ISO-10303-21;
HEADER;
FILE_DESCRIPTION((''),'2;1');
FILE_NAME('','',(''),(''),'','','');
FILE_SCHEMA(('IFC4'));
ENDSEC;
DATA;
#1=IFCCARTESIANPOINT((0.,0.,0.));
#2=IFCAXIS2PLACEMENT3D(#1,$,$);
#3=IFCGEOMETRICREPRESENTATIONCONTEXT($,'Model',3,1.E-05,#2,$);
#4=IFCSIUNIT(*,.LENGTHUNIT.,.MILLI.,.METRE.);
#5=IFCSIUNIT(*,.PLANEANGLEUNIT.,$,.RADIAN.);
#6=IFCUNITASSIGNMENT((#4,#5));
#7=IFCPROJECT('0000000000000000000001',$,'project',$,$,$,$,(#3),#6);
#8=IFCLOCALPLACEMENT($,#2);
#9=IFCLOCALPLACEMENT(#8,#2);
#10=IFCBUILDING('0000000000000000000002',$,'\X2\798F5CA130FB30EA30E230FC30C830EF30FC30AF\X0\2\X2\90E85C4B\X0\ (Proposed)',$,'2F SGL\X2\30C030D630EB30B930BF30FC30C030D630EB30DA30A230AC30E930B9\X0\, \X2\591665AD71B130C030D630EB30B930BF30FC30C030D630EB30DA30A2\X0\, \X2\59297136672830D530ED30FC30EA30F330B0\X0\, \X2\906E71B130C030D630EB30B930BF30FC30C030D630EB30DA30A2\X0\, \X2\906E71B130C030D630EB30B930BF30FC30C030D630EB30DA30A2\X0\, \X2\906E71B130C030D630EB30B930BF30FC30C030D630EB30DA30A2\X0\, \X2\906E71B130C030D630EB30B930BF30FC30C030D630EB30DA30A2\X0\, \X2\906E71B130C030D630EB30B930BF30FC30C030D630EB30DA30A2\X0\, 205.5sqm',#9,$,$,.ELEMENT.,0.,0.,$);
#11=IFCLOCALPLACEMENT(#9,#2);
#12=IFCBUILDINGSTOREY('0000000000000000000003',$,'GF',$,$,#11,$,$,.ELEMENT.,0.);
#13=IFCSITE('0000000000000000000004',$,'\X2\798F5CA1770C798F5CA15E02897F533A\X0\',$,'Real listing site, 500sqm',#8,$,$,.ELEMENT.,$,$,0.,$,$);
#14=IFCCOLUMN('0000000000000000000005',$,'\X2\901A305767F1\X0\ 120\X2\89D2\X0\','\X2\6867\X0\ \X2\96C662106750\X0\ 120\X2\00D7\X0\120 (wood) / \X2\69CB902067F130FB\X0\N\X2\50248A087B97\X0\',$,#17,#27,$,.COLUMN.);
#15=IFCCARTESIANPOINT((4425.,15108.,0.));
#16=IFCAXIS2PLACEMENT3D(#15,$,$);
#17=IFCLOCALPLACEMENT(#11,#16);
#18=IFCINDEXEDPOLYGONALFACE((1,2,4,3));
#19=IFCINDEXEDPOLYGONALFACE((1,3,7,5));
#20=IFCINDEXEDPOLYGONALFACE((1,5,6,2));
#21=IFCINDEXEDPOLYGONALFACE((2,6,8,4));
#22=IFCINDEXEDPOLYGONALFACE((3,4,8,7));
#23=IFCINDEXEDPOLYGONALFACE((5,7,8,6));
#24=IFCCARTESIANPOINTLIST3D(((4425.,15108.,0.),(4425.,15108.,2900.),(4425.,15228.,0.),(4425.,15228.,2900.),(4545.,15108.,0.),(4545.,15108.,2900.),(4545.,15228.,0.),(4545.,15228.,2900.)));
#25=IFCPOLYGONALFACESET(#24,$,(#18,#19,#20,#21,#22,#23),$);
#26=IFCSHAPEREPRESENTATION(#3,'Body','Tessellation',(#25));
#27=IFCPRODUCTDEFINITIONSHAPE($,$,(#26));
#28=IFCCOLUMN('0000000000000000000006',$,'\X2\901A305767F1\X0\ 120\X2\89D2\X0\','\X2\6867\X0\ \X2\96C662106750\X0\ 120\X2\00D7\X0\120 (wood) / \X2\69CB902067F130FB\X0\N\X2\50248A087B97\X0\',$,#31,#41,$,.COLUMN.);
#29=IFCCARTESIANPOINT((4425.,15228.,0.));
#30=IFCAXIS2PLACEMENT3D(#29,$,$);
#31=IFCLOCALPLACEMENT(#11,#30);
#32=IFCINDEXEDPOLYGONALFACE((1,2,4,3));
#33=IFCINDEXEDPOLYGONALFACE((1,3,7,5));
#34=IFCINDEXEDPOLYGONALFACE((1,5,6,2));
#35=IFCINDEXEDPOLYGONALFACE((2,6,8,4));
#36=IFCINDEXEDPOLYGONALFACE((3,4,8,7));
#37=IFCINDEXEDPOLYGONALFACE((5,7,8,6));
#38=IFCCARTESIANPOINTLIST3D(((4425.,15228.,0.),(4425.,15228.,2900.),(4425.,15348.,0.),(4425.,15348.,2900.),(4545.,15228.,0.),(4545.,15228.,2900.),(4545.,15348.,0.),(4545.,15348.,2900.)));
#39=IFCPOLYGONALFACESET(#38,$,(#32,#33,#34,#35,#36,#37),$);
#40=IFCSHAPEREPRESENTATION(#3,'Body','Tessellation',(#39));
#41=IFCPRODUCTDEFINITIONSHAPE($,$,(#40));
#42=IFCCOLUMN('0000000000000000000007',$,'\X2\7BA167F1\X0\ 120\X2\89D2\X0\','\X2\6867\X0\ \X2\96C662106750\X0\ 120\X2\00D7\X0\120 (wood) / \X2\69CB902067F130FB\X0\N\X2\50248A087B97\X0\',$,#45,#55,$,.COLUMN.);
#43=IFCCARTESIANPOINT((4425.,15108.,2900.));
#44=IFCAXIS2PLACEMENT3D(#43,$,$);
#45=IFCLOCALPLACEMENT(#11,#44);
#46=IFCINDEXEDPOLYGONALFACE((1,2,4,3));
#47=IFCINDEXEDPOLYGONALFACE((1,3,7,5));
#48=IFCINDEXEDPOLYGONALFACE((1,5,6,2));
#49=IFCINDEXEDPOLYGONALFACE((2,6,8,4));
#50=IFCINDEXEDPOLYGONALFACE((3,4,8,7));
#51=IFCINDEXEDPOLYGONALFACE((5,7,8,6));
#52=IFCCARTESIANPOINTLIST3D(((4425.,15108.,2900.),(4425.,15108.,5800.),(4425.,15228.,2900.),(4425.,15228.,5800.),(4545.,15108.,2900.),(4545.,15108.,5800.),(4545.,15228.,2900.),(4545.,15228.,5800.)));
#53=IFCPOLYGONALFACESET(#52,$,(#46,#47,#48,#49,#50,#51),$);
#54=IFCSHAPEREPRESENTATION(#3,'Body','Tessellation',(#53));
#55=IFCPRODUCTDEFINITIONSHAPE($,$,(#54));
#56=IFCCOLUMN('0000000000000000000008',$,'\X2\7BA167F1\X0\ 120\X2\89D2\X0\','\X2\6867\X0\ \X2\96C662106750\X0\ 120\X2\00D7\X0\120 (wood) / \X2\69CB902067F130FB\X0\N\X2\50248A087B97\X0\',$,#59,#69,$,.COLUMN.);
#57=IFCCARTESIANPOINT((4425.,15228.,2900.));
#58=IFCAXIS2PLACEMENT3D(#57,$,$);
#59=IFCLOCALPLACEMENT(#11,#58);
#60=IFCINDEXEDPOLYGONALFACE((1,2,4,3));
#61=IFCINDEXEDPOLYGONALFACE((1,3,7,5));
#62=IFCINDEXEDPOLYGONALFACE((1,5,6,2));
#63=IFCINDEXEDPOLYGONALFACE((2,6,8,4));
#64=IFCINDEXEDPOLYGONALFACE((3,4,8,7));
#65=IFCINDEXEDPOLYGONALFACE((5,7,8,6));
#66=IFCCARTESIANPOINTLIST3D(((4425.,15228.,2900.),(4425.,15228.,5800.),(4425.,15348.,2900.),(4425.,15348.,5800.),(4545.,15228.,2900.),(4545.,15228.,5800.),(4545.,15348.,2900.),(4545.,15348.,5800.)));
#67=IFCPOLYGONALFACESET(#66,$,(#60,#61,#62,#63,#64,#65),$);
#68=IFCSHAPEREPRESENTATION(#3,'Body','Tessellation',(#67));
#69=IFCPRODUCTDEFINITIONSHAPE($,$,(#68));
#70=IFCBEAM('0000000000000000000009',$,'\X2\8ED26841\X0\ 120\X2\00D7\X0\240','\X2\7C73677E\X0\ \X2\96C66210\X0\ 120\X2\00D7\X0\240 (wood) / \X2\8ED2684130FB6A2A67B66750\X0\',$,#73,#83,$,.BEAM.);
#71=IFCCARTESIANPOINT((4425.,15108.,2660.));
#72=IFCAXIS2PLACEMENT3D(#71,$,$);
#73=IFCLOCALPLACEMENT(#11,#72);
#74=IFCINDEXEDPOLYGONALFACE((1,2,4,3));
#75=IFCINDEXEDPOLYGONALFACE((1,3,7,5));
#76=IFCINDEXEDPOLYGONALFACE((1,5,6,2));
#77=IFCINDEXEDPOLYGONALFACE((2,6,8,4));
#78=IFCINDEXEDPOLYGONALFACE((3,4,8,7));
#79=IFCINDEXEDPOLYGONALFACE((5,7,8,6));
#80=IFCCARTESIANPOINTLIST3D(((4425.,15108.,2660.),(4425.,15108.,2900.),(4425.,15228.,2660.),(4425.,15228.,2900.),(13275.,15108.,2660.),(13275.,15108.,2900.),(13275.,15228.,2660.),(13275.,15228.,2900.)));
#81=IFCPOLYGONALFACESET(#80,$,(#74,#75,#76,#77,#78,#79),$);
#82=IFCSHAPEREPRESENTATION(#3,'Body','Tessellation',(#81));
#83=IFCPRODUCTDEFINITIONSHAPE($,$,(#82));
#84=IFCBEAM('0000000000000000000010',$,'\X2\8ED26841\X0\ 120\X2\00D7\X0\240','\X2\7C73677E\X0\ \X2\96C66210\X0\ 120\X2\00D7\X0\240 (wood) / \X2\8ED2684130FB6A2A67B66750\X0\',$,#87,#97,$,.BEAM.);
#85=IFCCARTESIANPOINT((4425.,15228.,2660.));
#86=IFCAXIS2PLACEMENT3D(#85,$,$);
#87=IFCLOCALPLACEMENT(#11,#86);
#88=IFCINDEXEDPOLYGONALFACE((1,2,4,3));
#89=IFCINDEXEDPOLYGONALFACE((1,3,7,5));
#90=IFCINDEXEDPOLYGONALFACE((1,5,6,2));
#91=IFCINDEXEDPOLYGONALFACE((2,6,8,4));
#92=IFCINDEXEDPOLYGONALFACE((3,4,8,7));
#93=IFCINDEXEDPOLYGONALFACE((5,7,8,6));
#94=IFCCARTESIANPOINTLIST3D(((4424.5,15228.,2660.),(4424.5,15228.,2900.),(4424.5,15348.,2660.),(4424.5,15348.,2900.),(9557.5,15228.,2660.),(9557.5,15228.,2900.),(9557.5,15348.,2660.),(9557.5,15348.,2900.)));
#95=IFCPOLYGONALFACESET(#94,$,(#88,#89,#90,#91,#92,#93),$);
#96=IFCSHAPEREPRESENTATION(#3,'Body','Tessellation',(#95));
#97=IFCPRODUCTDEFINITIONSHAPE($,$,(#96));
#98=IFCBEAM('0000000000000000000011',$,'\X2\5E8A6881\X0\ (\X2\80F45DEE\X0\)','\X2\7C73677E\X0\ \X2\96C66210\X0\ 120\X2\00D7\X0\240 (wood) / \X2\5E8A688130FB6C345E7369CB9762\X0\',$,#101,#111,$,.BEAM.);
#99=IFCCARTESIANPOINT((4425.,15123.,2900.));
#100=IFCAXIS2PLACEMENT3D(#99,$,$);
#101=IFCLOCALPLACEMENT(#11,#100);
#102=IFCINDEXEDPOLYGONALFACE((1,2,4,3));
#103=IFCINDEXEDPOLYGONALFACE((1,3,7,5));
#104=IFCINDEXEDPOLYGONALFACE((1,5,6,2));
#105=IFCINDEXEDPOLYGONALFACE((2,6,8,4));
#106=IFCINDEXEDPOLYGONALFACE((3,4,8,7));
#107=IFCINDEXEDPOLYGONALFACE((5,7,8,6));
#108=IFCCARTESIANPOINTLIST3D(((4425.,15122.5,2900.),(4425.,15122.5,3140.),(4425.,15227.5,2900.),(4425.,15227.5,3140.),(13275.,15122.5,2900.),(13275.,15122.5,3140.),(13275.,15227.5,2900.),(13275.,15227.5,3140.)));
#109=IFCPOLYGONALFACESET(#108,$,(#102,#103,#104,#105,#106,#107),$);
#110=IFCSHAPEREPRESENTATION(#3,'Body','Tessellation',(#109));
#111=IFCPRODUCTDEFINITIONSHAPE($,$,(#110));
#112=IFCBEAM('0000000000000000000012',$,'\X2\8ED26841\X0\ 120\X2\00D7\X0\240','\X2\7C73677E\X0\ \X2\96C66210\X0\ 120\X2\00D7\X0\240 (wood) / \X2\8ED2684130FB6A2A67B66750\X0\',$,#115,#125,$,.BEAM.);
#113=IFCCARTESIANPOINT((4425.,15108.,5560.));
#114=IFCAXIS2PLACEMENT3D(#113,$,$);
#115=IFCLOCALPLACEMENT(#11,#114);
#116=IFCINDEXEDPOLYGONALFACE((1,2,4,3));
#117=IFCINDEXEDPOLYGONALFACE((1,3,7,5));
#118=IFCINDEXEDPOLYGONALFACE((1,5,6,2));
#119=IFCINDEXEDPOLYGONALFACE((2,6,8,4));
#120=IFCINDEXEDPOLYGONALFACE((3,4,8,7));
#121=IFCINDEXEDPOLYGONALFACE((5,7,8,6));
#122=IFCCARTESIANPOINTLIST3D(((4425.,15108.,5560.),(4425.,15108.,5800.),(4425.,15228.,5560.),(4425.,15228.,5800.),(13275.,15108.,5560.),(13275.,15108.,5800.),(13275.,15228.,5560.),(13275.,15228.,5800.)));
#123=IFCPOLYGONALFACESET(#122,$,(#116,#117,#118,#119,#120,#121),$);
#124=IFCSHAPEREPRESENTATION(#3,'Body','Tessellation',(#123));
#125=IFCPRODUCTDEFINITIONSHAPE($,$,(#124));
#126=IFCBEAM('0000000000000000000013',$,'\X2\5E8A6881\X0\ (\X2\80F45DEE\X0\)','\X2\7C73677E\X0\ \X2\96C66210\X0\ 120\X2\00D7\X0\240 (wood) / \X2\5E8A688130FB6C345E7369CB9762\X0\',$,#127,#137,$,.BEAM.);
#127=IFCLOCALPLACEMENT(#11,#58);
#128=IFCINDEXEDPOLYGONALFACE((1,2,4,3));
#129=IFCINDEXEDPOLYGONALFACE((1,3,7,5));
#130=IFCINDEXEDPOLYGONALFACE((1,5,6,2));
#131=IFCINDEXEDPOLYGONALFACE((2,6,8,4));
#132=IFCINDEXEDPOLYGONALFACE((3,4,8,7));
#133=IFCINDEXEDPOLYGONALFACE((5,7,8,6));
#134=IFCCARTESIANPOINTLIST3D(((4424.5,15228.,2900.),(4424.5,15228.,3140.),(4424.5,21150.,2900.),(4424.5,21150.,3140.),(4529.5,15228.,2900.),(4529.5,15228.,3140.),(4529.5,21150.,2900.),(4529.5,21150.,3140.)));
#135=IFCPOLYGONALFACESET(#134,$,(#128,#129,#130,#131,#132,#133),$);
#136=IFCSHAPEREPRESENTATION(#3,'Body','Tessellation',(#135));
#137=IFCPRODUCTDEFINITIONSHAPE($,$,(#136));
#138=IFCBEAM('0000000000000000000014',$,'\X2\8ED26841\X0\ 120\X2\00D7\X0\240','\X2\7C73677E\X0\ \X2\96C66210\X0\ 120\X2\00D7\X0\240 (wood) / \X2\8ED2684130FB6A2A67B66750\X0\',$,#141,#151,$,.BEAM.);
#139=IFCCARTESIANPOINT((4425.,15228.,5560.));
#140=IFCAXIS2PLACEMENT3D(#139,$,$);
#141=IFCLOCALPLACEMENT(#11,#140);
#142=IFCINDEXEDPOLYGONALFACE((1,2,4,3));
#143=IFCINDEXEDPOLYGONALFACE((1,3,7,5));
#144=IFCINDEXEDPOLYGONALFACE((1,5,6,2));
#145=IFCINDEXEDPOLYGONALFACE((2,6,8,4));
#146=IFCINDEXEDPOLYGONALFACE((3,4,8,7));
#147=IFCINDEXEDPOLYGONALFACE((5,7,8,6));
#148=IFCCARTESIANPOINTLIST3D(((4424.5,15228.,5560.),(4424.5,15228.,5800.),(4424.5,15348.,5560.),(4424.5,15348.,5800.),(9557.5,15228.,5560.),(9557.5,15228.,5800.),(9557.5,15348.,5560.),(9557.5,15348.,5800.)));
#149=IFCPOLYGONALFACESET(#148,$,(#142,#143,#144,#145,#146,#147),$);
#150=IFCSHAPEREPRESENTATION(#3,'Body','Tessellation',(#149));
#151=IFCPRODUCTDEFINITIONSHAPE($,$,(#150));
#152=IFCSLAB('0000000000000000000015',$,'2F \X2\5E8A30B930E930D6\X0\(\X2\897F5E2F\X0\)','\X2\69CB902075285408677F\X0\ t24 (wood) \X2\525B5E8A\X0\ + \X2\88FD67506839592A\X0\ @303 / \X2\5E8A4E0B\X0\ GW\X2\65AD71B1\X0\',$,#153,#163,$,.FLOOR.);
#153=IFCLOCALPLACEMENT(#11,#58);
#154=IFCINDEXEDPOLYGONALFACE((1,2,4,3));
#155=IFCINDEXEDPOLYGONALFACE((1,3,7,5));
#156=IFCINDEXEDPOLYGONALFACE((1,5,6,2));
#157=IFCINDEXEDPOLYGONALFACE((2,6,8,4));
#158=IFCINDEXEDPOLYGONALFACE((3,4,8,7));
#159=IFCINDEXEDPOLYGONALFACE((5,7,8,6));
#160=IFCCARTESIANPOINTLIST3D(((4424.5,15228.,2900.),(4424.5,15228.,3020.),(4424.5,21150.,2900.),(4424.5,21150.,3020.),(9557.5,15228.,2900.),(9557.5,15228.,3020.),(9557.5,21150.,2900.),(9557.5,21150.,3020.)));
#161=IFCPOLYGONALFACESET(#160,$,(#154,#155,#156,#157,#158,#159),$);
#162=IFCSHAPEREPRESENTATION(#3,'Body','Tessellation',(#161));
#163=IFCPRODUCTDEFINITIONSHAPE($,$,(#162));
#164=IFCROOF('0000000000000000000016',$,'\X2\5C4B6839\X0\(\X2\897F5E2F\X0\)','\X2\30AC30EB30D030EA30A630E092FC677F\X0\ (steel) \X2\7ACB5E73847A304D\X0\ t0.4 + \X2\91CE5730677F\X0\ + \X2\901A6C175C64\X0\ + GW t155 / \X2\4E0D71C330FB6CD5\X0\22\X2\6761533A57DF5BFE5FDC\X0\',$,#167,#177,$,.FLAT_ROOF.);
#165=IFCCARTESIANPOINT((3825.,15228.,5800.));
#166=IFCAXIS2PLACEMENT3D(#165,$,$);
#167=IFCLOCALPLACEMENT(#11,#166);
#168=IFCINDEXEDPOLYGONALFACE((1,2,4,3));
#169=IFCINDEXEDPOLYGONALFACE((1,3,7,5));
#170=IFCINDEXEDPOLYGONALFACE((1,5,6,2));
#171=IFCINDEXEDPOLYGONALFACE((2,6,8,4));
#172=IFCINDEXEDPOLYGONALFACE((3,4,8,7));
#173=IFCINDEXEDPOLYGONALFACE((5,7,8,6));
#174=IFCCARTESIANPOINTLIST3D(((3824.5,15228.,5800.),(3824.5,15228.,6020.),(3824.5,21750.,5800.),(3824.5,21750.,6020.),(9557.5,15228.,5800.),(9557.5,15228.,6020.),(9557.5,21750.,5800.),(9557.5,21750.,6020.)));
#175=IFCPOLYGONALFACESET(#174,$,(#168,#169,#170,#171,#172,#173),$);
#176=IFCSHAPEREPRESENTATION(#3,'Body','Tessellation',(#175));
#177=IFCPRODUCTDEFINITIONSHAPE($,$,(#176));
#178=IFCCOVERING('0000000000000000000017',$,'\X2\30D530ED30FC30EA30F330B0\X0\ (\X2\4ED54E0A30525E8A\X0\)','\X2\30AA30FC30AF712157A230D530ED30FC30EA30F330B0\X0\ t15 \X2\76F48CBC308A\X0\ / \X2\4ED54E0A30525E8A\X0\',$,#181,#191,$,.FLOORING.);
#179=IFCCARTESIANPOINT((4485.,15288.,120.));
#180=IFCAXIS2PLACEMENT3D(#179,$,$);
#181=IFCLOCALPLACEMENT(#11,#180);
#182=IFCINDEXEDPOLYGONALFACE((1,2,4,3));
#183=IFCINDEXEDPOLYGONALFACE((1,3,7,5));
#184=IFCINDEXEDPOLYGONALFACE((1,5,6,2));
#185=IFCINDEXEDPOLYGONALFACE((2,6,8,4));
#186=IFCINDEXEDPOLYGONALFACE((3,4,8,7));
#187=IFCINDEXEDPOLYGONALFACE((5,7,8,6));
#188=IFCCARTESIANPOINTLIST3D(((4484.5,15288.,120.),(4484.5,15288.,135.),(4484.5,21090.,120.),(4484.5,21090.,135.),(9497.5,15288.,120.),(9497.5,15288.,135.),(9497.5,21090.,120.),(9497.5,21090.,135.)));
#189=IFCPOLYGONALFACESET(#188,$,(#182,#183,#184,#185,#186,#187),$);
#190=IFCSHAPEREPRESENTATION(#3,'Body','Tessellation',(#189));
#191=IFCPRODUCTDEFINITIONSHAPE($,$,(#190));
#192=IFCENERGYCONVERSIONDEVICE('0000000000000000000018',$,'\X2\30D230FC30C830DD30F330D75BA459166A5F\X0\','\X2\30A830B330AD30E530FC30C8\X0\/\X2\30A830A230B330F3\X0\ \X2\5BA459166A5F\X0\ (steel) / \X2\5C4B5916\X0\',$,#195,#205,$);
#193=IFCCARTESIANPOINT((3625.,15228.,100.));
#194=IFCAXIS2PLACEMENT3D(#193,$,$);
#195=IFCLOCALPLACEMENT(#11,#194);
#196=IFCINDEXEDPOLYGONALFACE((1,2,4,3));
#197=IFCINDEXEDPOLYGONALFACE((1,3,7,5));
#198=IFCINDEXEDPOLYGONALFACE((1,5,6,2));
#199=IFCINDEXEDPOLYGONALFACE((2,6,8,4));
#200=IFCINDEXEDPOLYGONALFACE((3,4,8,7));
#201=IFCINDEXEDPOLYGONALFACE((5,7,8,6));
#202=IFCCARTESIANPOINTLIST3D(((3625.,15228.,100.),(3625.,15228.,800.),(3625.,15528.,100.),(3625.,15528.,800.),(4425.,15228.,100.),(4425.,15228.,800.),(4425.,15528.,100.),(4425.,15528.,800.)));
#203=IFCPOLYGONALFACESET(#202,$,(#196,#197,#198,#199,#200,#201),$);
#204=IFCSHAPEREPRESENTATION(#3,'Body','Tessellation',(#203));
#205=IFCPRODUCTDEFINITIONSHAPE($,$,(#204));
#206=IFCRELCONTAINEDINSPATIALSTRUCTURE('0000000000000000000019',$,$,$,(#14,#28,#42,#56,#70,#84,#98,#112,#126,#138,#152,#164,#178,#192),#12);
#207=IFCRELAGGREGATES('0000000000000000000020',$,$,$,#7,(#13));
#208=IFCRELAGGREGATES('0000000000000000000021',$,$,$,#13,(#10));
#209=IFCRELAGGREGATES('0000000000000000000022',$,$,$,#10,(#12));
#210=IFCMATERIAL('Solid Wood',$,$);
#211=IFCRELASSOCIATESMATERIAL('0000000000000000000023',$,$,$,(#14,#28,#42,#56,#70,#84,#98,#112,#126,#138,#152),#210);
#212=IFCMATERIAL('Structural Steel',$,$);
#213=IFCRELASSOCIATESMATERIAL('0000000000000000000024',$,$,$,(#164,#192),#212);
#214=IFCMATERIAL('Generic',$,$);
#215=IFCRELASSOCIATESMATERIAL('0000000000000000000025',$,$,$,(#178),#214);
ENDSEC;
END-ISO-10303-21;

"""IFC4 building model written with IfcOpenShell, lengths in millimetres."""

from ifc_helpers import new_model, si_unit, frame, frame_2d, origin, place, context, project, spatial, rectangle, extrude, material, element, save


model = new_model("IFC4")

# Units and contexts
model_context = context("Model", 3, precision=1e-05, world=origin())
ifc_project = project(units=[si_unit("LENGTHUNIT", "METRE", prefix="MILLI"), si_unit("PLANEANGLEUNIT", "RADIAN")], contexts=[model_context])

# Site, building, storey
site_placement = place(None, origin())
site = spatial("IfcSite", under=ifc_project, at=site_placement, Name="福岡県福岡市西区", ObjectType="Real listing site, 500sqm", CompositionType="ELEMENT", RefElevation=0.0)
building_placement = place(site_placement, origin())
building = spatial("IfcBuilding", under=site, at=building_placement, Name="福岡・リモートワーク2部屋 (Proposed)", ObjectType="2F SGLダブルスターダブルペアガラス, 外断熱ダブルスターダブルペア, 天然木フローリング, 遮熱ダブルスターダブルペア, 遮熱ダブルスターダブルペア, 遮熱ダブルスターダブルペア, 遮熱ダブルスターダブルペア, 遮熱ダブルスターダブルペア, 205.5sqm", CompositionType="ELEMENT", ElevationOfRefHeight=0.0, ElevationOfTerrain=0.0)
storey_placement = place(building_placement, origin())
storey = spatial("IfcBuildingStorey", under=building, at=storey_placement, Name="GF", CompositionType="ELEMENT", Elevation=0.0)

# Columns
ifc_material_1 = material(Name="Solid Wood")
column_1_placement = place(storey_placement, frame((4425.0, 15108.0, 0.0)))
element("IfcColumn", 1, at=column_1_placement, inside=storey, material=ifc_material_1, Name="通し柱 120角", Description="桧 集成材 120×120 (wood) / 構造柱・N値計算", PredefinedType="COLUMN", context=model_context, shape_type="SweptSolid", body=[
    extrude(rectangle(XDim=120.0, YDim=120.0, at=frame_2d((60.0, 60.0))), frame((4425.0, 15108.0, 0.0)), (0.0, 0.0, 1.0), 2900.0),
])
column_2_placement = place(storey_placement, frame((4425.0, 15228.0, 0.0)))
element("IfcColumn", 2, at=column_2_placement, inside=storey, material=ifc_material_1, Name="通し柱 120角", Description="桧 集成材 120×120 (wood) / 構造柱・N値計算", PredefinedType="COLUMN", context=model_context, shape_type="SweptSolid", body=[
    extrude(rectangle(XDim=120.0, YDim=120.0, at=frame_2d((60.0, 60.0))), frame((4425.0, 15228.0, 0.0)), (0.0, 0.0, 1.0), 2900.0),
])
column_3_placement = place(storey_placement, frame((4425.0, 15108.0, 2900.0)))
element("IfcColumn", 3, at=column_3_placement, inside=storey, material=ifc_material_1, Name="管柱 120角", Description="桧 集成材 120×120 (wood) / 構造柱・N値計算", PredefinedType="COLUMN", context=model_context, shape_type="SweptSolid", body=[
    extrude(rectangle(XDim=120.0, YDim=120.0, at=frame_2d((60.0, 60.0))), frame((4425.0, 15108.0, 2900.0)), (0.0, 0.0, 1.0), 2900.0),
])
column_4_placement = place(storey_placement, frame((4425.0, 15228.0, 2900.0)))
element("IfcColumn", 4, at=column_4_placement, inside=storey, material=ifc_material_1, Name="管柱 120角", Description="桧 集成材 120×120 (wood) / 構造柱・N値計算", PredefinedType="COLUMN", context=model_context, shape_type="SweptSolid", body=[
    extrude(rectangle(XDim=120.0, YDim=120.0, at=frame_2d((60.0, 60.0))), frame((4425.0, 15228.0, 2900.0)), (0.0, 0.0, 1.0), 2900.0),
])

# Beams
beam_1_placement = place(storey_placement, frame((4425.0, 15108.0, 2660.0)))
element("IfcBeam", 5, at=beam_1_placement, inside=storey, material=ifc_material_1, Name="軒桁 120×240", Description="米松 集成 120×240 (wood) / 軒桁・横架材", PredefinedType="BEAM", context=model_context, shape_type="SweptSolid", body=[
    extrude(rectangle(XDim=8850.0, YDim=120.0, at=frame_2d((4425.0, 60.0))), frame((4425.0, 15108.0, 2660.0)), (0.0, 0.0, 1.0), 240.0),
])
beam_2_placement = place(storey_placement, frame((4425.0, 15228.0, 2660.0)))
element("IfcBeam", 6, at=beam_2_placement, inside=storey, material=ifc_material_1, Name="軒桁 120×240", Description="米松 集成 120×240 (wood) / 軒桁・横架材", PredefinedType="BEAM", context=model_context, shape_type="SweptSolid", body=[
    extrude(rectangle(XDim=5133.0, YDim=120.0, at=frame_2d((2566.0, 60.0))), frame((4425.0, 15228.0, 2660.0)), (0.0, 0.0, 1.0), 240.0),
])
beam_3_placement = place(storey_placement, frame((4425.0, 15123.0, 2900.0)))
element("IfcBeam", 7, at=beam_3_placement, inside=storey, material=ifc_material_1, Name="床梁 (胴差)", Description="米松 集成 120×240 (wood) / 床梁・水平構面", PredefinedType="BEAM", context=model_context, shape_type="SweptSolid", body=[
    extrude(rectangle(XDim=8850.0, YDim=105.0, at=frame_2d((4425.0, 52.0))), frame((4425.0, 15123.0, 2900.0)), (0.0, 0.0, 1.0), 240.0),
])
beam_4_placement = place(storey_placement, frame((4425.0, 15108.0, 5560.0)))
element("IfcBeam", 8, at=beam_4_placement, inside=storey, material=ifc_material_1, Name="軒桁 120×240", Description="米松 集成 120×240 (wood) / 軒桁・横架材", PredefinedType="BEAM", context=model_context, shape_type="SweptSolid", body=[
    extrude(rectangle(XDim=8850.0, YDim=120.0, at=frame_2d((4425.0, 60.0))), frame((4425.0, 15108.0, 5560.0)), (0.0, 0.0, 1.0), 240.0),
])
beam_5_placement = place(storey_placement, frame((4425.0, 15228.0, 2900.0)))
element("IfcBeam", 9, at=beam_5_placement, inside=storey, material=ifc_material_1, Name="床梁 (胴差)", Description="米松 集成 120×240 (wood) / 床梁・水平構面", PredefinedType="BEAM", context=model_context, shape_type="SweptSolid", body=[
    extrude(rectangle(XDim=105.0, YDim=5922.0, at=frame_2d((52.0, 2961.0))), frame((4425.0, 15228.0, 2900.0)), (0.0, 0.0, 1.0), 240.0),
])
beam_6_placement = place(storey_placement, frame((4425.0, 15228.0, 5560.0)))
element("IfcBeam", 10, at=beam_6_placement, inside=storey, material=ifc_material_1, Name="軒桁 120×240", Description="米松 集成 120×240 (wood) / 軒桁・横架材", PredefinedType="BEAM", context=model_context, shape_type="SweptSolid", body=[
    extrude(rectangle(XDim=5133.0, YDim=120.0, at=frame_2d((2566.0, 60.0))), frame((4425.0, 15228.0, 5560.0)), (0.0, 0.0, 1.0), 240.0),
])

# Slab
slab_1_placement = place(storey_placement, frame((4425.0, 15228.0, 2900.0)))
element("IfcSlab", 11, at=slab_1_placement, inside=storey, material=ifc_material_1, Name="2F 床スラブ(西帯)", Description="構造用合板 t24 (wood) 剛床 + 製材根太 @303 / 床下 GW断熱", PredefinedType="FLOOR", context=model_context, shape_type="SweptSolid", body=[
    extrude(rectangle(XDim=5133.0, YDim=5922.0, at=frame_2d((2566.0, 2961.0))), frame((4425.0, 15228.0, 2900.0)), (0.0, 0.0, 1.0), 120.0),
])

# Roof
ifc_material_2 = material(Name="Structural Steel")
for number, where, name in (
    (12, (3825.0, 15228.0, 5800.0), "屋根(西帯)"),
):
    element("IfcRoof", number, at=place(storey_placement, frame(where)), inside=storey, material=ifc_material_2, Name=name, Description="ガルバリウム鋼板 (steel) 立平葺き t0.4 + 野地板 + 通気層 + GW t155 / 不燃・法22条区域対応", PredefinedType="FLAT_ROOF", context=model_context, shape_type="SweptSolid", body=[
        extrude(rectangle(XDim=5733.0, YDim=6522.0, at=frame_2d((2866.0, 3261.0))), frame((3825.0, 15228.0, 5800.0)), (0.0, 0.0, 1.0), 220.0),
    ])

# Covering
ifc_material_3 = material(Name="Generic")
covering_placement = place(storey_placement, frame((4485.0, 15288.0, 120.0)))
element("IfcCovering", 13, at=covering_placement, inside=storey, material=ifc_material_3, Name="フローリング (仕上げ床)", Description="オーク無垢フローリング t15 直貼り / 仕上げ床", PredefinedType="FLOORING", context=model_context, shape_type="SweptSolid", body=[
    extrude(rectangle(XDim=5013.0, YDim=5802.0, at=frame_2d((2506.0, 2901.0))), frame((4485.0, 15288.0, 120.0)), (0.0, 0.0, 1.0), 15.0),
])

# Energy conversion device
energy_conversion_device_placement = place(storey_placement, frame((3625.0, 15228.0, 100.0)))
element("IfcEnergyConversionDevice", 14, at=energy_conversion_device_placement, inside=storey, material=ifc_material_2, Name="ヒートポンプ室外機", Description="エコキュート/エアコン 室外機 (steel) / 屋外", context=model_context, shape_type="SweptSolid", body=[
    extrude(rectangle(XDim=800.0, YDim=300.0, at=frame_2d((400.0, 150.0))), frame((3625.0, 15228.0, 100.0)), (0.0, 0.0, 1.0), 700.0),
])

save(model, "model.ifc")
